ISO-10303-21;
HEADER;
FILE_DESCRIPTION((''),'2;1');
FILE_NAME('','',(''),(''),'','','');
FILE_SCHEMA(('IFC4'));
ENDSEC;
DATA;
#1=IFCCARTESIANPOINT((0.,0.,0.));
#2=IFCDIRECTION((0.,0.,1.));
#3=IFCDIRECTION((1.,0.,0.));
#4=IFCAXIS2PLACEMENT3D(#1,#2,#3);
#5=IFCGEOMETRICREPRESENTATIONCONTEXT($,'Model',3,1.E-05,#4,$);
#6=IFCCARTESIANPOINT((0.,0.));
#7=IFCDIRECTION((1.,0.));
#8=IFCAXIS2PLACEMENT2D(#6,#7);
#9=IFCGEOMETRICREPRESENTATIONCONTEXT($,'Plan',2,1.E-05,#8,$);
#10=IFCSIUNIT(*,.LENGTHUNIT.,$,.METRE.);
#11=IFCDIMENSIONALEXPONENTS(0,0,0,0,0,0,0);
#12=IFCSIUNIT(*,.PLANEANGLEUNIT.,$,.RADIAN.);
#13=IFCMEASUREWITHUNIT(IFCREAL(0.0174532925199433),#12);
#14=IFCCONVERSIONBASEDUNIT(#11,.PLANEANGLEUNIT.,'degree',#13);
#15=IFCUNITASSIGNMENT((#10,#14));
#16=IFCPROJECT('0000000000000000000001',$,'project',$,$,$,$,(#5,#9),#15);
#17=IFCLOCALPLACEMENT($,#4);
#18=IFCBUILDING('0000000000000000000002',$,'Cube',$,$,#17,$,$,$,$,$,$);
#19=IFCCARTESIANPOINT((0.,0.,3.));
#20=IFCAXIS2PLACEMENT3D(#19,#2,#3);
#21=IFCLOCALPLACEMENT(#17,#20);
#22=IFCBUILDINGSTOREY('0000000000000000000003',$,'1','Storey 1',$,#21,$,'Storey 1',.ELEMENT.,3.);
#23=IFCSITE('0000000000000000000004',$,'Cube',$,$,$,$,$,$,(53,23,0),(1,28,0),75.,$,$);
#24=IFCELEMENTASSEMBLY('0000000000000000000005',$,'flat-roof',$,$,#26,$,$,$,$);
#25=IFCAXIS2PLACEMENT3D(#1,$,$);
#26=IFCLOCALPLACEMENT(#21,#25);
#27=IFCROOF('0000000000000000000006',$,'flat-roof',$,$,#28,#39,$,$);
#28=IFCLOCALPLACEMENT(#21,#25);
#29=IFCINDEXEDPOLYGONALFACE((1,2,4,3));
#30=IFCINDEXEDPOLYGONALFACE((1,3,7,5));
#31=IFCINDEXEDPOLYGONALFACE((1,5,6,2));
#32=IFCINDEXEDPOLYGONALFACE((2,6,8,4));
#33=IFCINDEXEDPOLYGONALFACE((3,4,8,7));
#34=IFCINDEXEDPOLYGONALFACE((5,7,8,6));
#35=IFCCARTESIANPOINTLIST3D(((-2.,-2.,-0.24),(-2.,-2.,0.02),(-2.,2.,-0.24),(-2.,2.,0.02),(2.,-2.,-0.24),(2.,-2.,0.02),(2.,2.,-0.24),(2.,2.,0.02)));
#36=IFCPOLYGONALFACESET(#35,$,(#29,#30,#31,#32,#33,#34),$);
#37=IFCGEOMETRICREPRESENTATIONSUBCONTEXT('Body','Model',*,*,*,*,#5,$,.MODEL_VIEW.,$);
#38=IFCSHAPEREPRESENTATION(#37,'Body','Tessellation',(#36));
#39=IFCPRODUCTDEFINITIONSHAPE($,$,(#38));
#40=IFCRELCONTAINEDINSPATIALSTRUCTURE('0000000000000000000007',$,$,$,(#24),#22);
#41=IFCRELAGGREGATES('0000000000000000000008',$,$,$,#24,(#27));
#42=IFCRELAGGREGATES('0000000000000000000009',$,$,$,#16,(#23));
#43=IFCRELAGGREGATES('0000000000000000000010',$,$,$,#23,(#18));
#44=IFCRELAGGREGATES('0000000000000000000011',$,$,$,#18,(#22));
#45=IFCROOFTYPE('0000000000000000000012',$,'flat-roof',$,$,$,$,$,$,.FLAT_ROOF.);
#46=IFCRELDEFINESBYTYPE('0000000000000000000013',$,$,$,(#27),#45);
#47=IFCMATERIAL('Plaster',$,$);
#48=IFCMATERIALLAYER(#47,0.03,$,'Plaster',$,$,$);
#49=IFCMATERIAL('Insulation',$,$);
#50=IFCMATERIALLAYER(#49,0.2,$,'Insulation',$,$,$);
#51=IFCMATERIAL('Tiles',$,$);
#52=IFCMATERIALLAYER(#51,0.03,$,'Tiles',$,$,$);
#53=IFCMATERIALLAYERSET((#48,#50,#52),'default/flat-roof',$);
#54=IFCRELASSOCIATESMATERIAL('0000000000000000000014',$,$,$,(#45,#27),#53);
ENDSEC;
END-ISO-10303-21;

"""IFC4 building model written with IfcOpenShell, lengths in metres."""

from ifc_helpers import new_model, entity, si_unit, converted_unit, frame, origin, origin_with_axes, origin_2d_with_axis, place, context, subcontext, project, spatial, polyline, outline, extrude, material, layer, layer_set, layer_usage, type_object, element, aggregate, save


model = new_model("IFC4")

# Units and contexts
model_context = context("Model", 3, precision=1e-05, world=origin_with_axes())
plan_context = context("Plan", 2, precision=1e-05, world=origin_2d_with_axis())
body_context = subcontext(model_context, "Body", "Model", "MODEL_VIEW")
ifc_project = project(units=[si_unit("LENGTHUNIT", "METRE"), converted_unit("PLANEANGLEUNIT", "degree", entity("IfcReal", 0.0174532925199433), si_unit("PLANEANGLEUNIT", "RADIAN"), dimensions=[0, 0, 0, 0, 0, 0, 0])], contexts=[model_context, plan_context])

# Site, building, storey
site = spatial("IfcSite", under=ifc_project, Name="Cube", RefLatitude=(53, 23, 0), RefLongitude=(1, 28, 0), RefElevation=75.0)
building_placement = place(None, origin_with_axes())
building = spatial("IfcBuilding", under=site, at=building_placement, Name="Cube")
storey_placement = place(building_placement, frame((0.0, 0.0, 3.0), z_axis=(0.0, 0.0, 1.0), x_axis=(1.0, 0.0, 0.0)))
storey = spatial("IfcBuildingStorey", under=building, at=storey_placement, Name="1", Description="Storey 1", LongName="Storey 1", CompositionType="ELEMENT", Elevation=3.0)

# Element assembly, roof
assembly_1_placement = place(storey_placement, frame((0.0, 0.0, -3.0), z_axis=(0.0, 0.0, 1.0), x_axis=(1.0, 0.0, 0.0)))
assembly_1 = element("IfcElementAssembly", 1, at=assembly_1_placement, inside=storey, Name="flat-roof")
ifc_material_1 = material(Name="Plaster")
ifc_layer_1 = layer(ifc_material_1, 0.03, Name="Plaster")
ifc_material_2 = material(Name="Insulation")
ifc_layer_2 = layer(ifc_material_2, 0.2, Name="Insulation")
ifc_material_3 = material(Name="Tiles")
ifc_layer_3 = layer(ifc_material_3, 0.03, Name="Tiles")
ifc_layer_set = layer_set([ifc_layer_1, ifc_layer_2, ifc_layer_3], Name="default/flat-roof")
ifc_layer_usage = layer_usage(ifc_layer_set, "AXIS3", "POSITIVE", 0.0)
roof_type = type_object("IfcRoofType", Name="flat-roof", PredefinedType="FLAT_ROOF", material=ifc_layer_set)
roof_placement = place(assembly_1_placement, frame((-2.0, 2.0, 2.76), z_axis=(0.0, 0.0, 1.0), x_axis=(1.0, 0.0, 0.0)))
roof = element("IfcRoof", 2, at=roof_placement, type_object=roof_type, material=ifc_layer_usage, Name="flat-roof", context=body_context, shape_type="SweptSolid", body=[
    extrude(outline(polyline([(0.0, 0.0), (0.0, -4.0), (4.0, -4.0), (4.0, 0.0), (0.0, 0.0)])), origin(), (0.0, 0.0, 1.0), 0.26),
])
aggregate(assembly_1, [roof])

save(model, "model.ifc")
